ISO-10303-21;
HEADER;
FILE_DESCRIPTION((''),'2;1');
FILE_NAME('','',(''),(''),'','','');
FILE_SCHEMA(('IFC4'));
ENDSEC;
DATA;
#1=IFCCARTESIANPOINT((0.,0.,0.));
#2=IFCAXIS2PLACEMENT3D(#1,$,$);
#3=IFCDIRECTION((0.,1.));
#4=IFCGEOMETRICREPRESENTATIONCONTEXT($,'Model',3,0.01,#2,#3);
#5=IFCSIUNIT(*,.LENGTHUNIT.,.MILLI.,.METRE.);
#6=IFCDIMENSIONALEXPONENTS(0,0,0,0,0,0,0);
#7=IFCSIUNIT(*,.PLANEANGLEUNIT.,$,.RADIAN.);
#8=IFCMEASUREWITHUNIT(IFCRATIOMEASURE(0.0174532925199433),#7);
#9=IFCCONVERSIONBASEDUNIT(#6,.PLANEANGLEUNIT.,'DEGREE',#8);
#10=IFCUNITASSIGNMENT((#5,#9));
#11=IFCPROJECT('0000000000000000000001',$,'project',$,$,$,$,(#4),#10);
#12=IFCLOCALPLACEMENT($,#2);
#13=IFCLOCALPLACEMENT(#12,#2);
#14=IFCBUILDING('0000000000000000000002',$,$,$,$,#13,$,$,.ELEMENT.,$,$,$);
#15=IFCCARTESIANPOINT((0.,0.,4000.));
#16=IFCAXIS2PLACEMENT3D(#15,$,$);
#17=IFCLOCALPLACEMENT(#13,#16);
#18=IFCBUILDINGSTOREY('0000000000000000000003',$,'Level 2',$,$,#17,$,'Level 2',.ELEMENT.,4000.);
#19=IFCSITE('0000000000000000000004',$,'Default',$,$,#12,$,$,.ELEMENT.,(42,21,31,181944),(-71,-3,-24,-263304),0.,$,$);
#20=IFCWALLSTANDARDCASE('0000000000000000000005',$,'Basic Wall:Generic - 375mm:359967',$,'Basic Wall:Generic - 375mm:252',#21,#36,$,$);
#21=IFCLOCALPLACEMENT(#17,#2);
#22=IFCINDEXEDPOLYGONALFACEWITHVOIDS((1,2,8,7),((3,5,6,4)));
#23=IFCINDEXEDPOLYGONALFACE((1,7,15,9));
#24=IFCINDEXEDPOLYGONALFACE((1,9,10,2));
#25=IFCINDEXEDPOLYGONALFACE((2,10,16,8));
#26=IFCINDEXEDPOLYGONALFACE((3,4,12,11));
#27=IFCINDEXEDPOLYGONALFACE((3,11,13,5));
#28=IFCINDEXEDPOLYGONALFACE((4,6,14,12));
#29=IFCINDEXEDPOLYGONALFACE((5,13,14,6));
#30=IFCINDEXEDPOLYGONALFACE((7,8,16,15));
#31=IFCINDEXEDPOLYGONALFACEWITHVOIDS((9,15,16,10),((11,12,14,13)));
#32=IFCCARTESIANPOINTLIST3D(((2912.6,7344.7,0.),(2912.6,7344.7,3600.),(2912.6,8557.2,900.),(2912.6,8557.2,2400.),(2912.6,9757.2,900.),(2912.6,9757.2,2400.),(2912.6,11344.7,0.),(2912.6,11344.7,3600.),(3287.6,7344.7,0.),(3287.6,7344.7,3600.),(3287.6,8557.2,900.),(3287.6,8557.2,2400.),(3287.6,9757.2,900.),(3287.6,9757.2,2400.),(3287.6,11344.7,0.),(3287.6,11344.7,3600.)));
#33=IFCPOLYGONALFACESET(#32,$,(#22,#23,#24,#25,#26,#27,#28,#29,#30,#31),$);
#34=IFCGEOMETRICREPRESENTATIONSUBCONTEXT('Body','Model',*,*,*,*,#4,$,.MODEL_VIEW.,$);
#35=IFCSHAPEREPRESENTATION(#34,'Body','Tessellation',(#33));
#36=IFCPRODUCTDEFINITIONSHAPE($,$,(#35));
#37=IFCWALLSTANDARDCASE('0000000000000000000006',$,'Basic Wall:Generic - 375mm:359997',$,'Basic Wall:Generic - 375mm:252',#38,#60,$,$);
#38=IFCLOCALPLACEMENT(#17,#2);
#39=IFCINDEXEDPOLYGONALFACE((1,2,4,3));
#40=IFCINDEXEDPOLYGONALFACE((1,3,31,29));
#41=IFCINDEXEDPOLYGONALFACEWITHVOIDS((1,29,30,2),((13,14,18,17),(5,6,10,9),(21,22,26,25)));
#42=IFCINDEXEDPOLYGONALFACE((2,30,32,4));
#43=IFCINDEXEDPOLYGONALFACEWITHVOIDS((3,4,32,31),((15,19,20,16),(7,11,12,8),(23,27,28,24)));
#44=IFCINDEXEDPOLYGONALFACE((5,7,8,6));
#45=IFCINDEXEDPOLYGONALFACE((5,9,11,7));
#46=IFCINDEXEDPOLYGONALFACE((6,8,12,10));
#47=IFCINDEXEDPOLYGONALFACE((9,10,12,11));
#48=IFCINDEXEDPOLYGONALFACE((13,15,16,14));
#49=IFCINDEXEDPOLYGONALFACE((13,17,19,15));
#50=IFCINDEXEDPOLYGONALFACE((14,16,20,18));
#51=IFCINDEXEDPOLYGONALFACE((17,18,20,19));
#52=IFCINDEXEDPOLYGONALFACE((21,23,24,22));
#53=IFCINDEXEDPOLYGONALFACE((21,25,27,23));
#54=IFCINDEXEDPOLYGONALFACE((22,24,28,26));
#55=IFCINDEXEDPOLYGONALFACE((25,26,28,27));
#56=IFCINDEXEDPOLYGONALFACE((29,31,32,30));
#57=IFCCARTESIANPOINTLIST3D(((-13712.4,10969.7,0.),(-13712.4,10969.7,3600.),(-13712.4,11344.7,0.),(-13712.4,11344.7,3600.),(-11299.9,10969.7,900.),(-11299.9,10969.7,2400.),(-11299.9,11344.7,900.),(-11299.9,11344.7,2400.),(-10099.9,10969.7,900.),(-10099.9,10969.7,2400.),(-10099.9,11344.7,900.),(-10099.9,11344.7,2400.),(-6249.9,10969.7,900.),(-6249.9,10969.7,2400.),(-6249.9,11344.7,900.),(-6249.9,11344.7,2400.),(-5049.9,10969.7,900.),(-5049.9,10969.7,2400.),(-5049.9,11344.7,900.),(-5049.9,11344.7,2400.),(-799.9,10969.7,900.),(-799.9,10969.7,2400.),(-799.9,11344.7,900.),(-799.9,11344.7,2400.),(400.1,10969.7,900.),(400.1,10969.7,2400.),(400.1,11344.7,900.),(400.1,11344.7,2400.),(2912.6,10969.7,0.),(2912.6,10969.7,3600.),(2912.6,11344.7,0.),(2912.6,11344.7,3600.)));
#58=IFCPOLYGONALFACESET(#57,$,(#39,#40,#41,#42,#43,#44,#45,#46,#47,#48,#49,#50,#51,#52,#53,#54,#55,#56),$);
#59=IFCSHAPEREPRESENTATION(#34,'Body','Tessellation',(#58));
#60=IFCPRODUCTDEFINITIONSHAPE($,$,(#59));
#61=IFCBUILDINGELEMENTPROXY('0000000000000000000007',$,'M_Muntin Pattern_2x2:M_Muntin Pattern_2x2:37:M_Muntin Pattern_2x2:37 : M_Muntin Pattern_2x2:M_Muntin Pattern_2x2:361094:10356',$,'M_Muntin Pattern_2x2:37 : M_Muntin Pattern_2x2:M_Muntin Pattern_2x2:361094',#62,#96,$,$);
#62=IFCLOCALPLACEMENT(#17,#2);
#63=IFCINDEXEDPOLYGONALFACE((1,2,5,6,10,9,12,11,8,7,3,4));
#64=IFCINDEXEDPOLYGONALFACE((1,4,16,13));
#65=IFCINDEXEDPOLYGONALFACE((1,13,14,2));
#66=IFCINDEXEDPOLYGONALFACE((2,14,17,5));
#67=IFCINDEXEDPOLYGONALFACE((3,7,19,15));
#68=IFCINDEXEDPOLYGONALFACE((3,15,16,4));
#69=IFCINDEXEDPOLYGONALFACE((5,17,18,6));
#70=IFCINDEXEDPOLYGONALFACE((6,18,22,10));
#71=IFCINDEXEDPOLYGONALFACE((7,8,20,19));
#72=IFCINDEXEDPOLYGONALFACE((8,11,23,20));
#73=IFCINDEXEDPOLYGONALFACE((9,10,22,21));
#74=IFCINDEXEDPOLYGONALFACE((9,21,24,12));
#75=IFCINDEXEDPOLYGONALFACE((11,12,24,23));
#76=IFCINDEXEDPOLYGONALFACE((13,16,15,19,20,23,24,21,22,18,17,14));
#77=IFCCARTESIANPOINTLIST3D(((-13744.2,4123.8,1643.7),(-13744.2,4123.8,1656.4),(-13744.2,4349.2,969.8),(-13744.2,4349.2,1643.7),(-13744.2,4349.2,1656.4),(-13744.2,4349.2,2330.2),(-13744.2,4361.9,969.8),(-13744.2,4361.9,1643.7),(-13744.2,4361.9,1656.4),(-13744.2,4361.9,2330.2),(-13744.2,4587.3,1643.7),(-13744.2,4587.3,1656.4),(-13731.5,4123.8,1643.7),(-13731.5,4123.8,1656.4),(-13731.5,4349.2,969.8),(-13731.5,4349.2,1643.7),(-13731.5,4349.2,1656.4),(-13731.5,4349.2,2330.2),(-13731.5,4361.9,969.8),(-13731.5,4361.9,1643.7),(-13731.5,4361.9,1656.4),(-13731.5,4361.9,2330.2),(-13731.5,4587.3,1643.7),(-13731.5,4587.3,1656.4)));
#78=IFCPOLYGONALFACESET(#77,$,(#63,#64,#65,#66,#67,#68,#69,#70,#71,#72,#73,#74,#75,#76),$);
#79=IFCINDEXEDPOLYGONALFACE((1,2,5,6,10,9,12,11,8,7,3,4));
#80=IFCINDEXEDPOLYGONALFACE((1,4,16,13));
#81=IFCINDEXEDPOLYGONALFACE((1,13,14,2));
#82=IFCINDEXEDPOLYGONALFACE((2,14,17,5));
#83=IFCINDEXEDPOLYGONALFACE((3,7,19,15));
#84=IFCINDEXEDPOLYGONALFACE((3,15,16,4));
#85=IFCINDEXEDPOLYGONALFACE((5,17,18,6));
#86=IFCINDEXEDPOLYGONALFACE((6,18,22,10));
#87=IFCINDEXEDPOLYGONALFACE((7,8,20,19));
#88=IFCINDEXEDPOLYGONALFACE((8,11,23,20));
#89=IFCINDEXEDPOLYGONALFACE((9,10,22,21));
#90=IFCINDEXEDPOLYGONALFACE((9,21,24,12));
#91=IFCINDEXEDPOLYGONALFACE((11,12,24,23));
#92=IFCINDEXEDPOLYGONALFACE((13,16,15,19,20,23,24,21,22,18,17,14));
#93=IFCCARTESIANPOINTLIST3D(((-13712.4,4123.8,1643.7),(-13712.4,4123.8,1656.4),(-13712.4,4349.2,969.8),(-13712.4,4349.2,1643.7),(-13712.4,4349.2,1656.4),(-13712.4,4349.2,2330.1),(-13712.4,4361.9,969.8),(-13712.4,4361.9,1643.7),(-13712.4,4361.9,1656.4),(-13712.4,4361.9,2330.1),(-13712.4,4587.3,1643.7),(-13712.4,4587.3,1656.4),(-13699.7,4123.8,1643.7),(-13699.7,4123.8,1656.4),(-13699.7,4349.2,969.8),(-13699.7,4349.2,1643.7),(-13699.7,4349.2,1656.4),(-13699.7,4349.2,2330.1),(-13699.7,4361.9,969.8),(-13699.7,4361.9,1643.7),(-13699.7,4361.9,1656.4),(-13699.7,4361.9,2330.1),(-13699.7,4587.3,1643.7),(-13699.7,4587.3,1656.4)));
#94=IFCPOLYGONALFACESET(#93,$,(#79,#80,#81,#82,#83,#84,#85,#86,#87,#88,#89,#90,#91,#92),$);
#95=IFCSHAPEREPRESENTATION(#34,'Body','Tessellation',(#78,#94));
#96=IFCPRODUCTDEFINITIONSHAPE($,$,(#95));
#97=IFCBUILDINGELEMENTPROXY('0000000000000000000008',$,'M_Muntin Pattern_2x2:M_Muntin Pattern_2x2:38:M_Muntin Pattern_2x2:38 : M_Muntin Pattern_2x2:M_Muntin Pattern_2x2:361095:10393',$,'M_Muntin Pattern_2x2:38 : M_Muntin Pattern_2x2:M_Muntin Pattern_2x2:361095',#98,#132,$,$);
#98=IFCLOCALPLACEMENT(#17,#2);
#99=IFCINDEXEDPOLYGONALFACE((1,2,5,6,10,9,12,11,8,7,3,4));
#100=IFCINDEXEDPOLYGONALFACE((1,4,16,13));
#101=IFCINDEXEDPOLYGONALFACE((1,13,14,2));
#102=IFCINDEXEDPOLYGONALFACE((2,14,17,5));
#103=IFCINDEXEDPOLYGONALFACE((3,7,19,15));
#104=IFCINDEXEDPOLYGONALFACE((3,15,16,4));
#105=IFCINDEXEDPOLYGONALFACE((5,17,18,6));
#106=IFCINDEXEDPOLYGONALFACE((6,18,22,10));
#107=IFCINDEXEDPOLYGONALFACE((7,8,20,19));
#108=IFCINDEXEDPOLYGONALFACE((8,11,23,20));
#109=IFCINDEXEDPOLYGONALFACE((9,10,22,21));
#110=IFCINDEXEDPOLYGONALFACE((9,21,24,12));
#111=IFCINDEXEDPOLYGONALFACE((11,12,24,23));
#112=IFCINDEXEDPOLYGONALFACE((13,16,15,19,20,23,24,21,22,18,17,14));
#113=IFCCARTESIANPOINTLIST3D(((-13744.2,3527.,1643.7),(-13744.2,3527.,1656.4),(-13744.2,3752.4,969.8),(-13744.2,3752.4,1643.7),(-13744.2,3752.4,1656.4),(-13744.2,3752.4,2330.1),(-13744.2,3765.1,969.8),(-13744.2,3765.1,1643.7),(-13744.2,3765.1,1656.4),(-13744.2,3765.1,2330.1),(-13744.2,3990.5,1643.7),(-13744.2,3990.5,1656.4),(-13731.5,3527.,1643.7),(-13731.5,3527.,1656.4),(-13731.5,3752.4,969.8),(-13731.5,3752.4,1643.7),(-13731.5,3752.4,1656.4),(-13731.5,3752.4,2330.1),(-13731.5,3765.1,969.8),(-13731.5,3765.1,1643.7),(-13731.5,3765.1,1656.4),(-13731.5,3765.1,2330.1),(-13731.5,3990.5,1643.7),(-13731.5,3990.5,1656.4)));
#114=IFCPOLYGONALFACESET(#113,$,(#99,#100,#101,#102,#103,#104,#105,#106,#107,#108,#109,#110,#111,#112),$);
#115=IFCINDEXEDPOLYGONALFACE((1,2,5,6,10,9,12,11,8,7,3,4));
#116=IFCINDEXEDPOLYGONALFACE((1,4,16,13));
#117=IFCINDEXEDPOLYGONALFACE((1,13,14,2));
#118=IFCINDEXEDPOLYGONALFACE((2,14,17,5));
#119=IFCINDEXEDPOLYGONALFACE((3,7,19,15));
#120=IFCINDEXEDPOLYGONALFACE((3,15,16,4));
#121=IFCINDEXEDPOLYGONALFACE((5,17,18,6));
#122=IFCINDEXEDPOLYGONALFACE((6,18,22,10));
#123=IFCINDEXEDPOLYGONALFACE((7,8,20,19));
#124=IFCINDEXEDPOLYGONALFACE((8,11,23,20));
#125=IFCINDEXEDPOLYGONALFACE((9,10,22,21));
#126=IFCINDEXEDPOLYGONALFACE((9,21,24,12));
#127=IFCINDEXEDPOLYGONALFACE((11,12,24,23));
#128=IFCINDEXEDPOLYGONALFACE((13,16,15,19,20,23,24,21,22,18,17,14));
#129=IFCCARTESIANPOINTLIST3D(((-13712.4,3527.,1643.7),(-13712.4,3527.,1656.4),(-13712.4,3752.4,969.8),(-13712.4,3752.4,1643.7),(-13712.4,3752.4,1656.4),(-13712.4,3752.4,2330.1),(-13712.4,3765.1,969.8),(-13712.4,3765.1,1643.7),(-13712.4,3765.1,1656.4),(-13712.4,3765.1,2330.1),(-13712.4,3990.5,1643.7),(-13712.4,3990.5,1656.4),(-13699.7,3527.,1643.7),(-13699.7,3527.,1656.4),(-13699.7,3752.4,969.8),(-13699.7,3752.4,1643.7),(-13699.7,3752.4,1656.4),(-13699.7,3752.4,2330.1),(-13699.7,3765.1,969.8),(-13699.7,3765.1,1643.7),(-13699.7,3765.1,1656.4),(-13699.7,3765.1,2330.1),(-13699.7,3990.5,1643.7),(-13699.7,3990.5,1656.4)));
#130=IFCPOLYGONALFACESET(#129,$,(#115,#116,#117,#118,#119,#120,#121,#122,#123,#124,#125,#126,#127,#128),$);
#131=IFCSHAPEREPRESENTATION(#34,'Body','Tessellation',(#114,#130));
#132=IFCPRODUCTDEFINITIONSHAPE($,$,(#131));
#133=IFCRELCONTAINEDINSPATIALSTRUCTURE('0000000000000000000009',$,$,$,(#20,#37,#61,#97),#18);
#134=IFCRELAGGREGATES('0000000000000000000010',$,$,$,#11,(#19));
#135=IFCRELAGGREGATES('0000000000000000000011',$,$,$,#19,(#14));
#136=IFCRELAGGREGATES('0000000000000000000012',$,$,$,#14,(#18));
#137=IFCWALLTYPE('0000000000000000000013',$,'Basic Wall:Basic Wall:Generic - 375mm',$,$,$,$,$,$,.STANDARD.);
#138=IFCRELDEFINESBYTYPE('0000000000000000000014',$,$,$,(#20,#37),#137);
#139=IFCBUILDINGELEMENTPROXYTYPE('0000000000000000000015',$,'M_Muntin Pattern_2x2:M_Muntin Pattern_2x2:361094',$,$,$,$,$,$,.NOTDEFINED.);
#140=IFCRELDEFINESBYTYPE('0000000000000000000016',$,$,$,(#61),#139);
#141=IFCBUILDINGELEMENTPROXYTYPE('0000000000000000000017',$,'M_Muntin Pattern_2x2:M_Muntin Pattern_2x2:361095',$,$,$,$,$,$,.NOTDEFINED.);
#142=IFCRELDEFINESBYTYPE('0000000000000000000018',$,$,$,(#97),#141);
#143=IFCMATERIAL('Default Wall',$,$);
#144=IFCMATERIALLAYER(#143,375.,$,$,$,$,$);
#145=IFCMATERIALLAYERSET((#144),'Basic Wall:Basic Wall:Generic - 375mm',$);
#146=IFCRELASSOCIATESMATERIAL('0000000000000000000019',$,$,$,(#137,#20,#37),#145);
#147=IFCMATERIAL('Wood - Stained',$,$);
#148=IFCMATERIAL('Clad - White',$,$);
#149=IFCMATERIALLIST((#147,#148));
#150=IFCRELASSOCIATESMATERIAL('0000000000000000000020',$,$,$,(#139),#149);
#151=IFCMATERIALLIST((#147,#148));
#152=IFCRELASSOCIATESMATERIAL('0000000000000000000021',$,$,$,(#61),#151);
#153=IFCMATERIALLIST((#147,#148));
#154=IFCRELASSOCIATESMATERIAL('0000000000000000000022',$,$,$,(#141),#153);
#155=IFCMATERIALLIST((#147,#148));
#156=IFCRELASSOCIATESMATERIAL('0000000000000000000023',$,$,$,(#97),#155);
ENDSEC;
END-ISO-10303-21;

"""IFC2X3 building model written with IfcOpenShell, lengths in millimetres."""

from ifc_helpers import new_model, entity, si_unit, converted_unit, direction, frame, frame_2d, origin, place, context, subcontext, project, spatial, polyline, rectangle, outline, extrude, source, transform, mapped, material, material_list, layer, layer_set, layer_usage, type_object, type_shapes, element, save


model = new_model("IFC2X3")

# Units and contexts
model_context = context("Model", 3, precision=0.01, world=origin(), true_north=direction((0.0, 1.0)))
body_context = subcontext(model_context, "Body", "Model", "MODEL_VIEW")
ifc_project = project(units=[si_unit("LENGTHUNIT", "METRE", prefix="MILLI"), converted_unit("PLANEANGLEUNIT", "DEGREE", entity("IfcRatioMeasure", 0.0174532925199433), si_unit("PLANEANGLEUNIT", "RADIAN"), dimensions=[0, 0, 0, 0, 0, 0, 0])], contexts=[model_context])

# Site, building, storey
site_placement = place(None, origin())
site = spatial("IfcSite", under=ifc_project, at=site_placement, Name="Default", CompositionType="ELEMENT", RefLatitude=(42, 21, 31, 181944), RefLongitude=(-71, -3, -24, -263304), RefElevation=0.0)
building_placement = place(site_placement, origin())
building = spatial("IfcBuilding", under=site, at=building_placement, CompositionType="ELEMENT")
storey_placement = place(building_placement, frame((0.0, 0.0, 4000.0)))
storey = spatial("IfcBuildingStorey", under=building, at=storey_placement, Name="Level 2", LongName="Level 2", CompositionType="ELEMENT", Elevation=4000.0)

# Wall, opening
ifc_material_1 = material(Name="Default Wall")
ifc_layer = layer(ifc_material_1, 375.0)
ifc_layer_set = layer_set([ifc_layer], Name="Basic Wall:Basic Wall:Generic - 375mm")
ifc_layer_usage_1 = layer_usage(ifc_layer_set, "AXIS2", "NEGATIVE", 187.5)
wall_type = type_object("IfcWallType", Name="Basic Wall:Basic Wall:Generic - 375mm", PredefinedType="STANDARD", material=ifc_layer_set)
wall_1_placement = place(storey_placement, frame((3100.1, 7344.7, 0.0), z_axis=(0.0, 0.0, 1.0), x_axis=(0.0, 1.0, 0.0)))
wall_1 = element("IfcWallStandardCase", 1, at=wall_1_placement, inside=storey, type_object=wall_type, material=ifc_layer_usage_1, Name="Basic Wall:Generic - 375mm:359967", ObjectType="Basic Wall:Generic - 375mm:252", context=body_context, shape_type="SweptSolid", body=[
    extrude(rectangle(XDim=4000.0, YDim=375.0, at=frame_2d((2000.0, 0.0), x_axis=(-1.0, 0.0))), origin(), (0.0, 0.0, 1.0), 3600.0),
])
opening_1_placement = place(wall_1_placement, frame((-7344.7, 3100.1, 0.0), z_axis=(0.0, 0.0, 1.0), x_axis=(0.0, -1.0, 0.0)))
element("IfcOpeningElement", 2, at=opening_1_placement, cuts=wall_1, ObjectType="Opening", context=body_context, shape_type="SweptSolid", body=[
    extrude(rectangle(XDim=1500.0, YDim=1200.0, at=frame_2d((0.0, 0.0), x_axis=(0.0, 1.0))), frame((3291.3, 9157.2, 1650.0), z_axis=(-1.0, 0.0, 0.0), x_axis=(0.0, -1.0, 0.0)), (0.0, 0.0, 1.0), 382.5),
])

# Wall, openings
ifc_layer_usage_2 = layer_usage(ifc_layer_set, "AXIS2", "NEGATIVE", 187.5)
wall_2_placement = place(storey_placement, frame((2912.6, 11157.2, 0.0), z_axis=(0.0, 0.0, 1.0), x_axis=(-1.0, 0.0, 0.0)))
wall_2 = element("IfcWallStandardCase", 3, at=wall_2_placement, inside=storey, type_object=wall_type, material=ifc_layer_usage_2, Name="Basic Wall:Generic - 375mm:359997", ObjectType="Basic Wall:Generic - 375mm:252", context=body_context, shape_type="SweptSolid", body=[
    extrude(rectangle(XDim=16625.0, YDim=375.0, at=frame_2d((8312.5, 0.0), x_axis=(-1.0, 0.0))), origin(), (0.0, 0.0, 1.0), 3600.0),
])
opening_2_placement = place(wall_2_placement, frame((2912.6, 11157.2, 0.0), z_axis=(0.0, 0.0, 1.0), x_axis=(-1.0, 0.0, 0.0)))
element("IfcOpeningElement", 4, at=opening_2_placement, cuts=wall_2, ObjectType="Opening", context=body_context, shape_type="SweptSolid", body=[
    extrude(rectangle(XDim=1500.0, YDim=1200.0, at=frame_2d((0.0, 0.0), x_axis=(0.0, 1.0))), frame((-5649.9, 11348.4, 1650.0), z_axis=(0.0, -1.0, 0.0), x_axis=(1.0, 0.0, 0.0)), (0.0, 0.0, 1.0), 382.5),
])
opening_3_placement = place(wall_2_placement, frame((2912.6, 11157.2, 0.0), z_axis=(0.0, 0.0, 1.0), x_axis=(-1.0, 0.0, 0.0)))
element("IfcOpeningElement", 5, at=opening_3_placement, cuts=wall_2, ObjectType="Opening", context=body_context, shape_type="SweptSolid", body=[
    extrude(rectangle(XDim=1500.0, YDim=1200.0, at=frame_2d((0.0, 0.0), x_axis=(0.0, 1.0))), frame((-199.9, 11348.4, 1650.0), z_axis=(0.0, -1.0, 0.0), x_axis=(1.0, 0.0, 0.0)), (0.0, 0.0, 1.0), 382.5),
])
opening_4_placement = place(wall_2_placement, frame((2912.6, 11157.2, 0.0), z_axis=(0.0, 0.0, 1.0), x_axis=(-1.0, 0.0, 0.0)))
element("IfcOpeningElement", 6, at=opening_4_placement, cuts=wall_2, ObjectType="Opening", context=body_context, shape_type="SweptSolid", body=[
    extrude(rectangle(XDim=1500.0, YDim=1200.0, at=frame_2d((0.0, 0.0), x_axis=(0.0, 1.0))), frame((-10699.9, 11348.4, 1650.0), z_axis=(0.0, -1.0, 0.0), x_axis=(1.0, 0.0, 0.0)), (0.0, 0.0, 1.0), 382.5),
])

# Building element proxies
ifc_material_2 = material(Name="Wood - Stained")
ifc_material_3 = material(Name="Clad - White")
ifc_material_list_1 = material_list([ifc_material_2, ifc_material_3])
ifc_material_list_2 = material_list([ifc_material_2, ifc_material_3])
building_element_proxy_type_1 = type_object("IfcBuildingElementProxyType", Name="M_Muntin Pattern_2x2:M_Muntin Pattern_2x2:361094", PredefinedType="NOTDEFINED", material=ifc_material_list_2)
shared_shape_1 = source(origin(), body_context, "Body", "SweptSolid", [
    extrude(outline(polyline([(-6.4, -680.2), (6.3, -680.2), (6.3, -6.4), (231.7, -6.4), (231.7, 6.3), (6.3, 6.3), (6.3, 680.2), (-6.4, 680.2), (-6.4, 6.3), (-231.7, 6.3), (-231.7, -6.4), (-6.4, -6.4), (-6.4, -680.2)])), frame((-13744.2, 4355.6, 5650.0), z_axis=(1.0, 0.0, 0.0), x_axis=(0.0, -1.0, 0.0)), (0.0, 0.0, 1.0), 12.7),
    extrude(outline(polyline([(-6.4, -680.1), (6.3, -680.1), (6.3, -6.4), (231.7, -6.4), (231.7, 6.3), (6.3, 6.3), (6.3, 680.2), (-6.4, 680.2), (-6.4, 6.3), (-231.7, 6.3), (-231.7, -6.4), (-6.4, -6.4), (-6.4, -680.1)])), frame((-13712.4, 4355.6, 5650.0), z_axis=(1.0, 0.0, 0.0), x_axis=(0.0, -1.0, 0.0)), (0.0, 0.0, 1.0), 12.7),
])
type_shapes(building_element_proxy_type_1, [shared_shape_1])
proxy_1_placement = place(storey_placement, frame((0.0, 0.0, -4000.0)))
element("IfcBuildingElementProxy", 7, at=proxy_1_placement, inside=storey, type_object=building_element_proxy_type_1, material=ifc_material_list_1, Name="M_Muntin Pattern_2x2:M_Muntin Pattern_2x2:37:M_Muntin Pattern_2x2:37 : M_Muntin Pattern_2x2:M_Muntin Pattern_2x2:361094:10356", ObjectType="M_Muntin Pattern_2x2:37 : M_Muntin Pattern_2x2:M_Muntin Pattern_2x2:361094", context=body_context, shape_type="MappedRepresentation", body=[
    mapped(shared_shape_1, transform((0.0, 0.0, 0.0), scale=1.0)),
])
ifc_material_list_3 = material_list([ifc_material_2, ifc_material_3])
ifc_material_list_4 = material_list([ifc_material_2, ifc_material_3])
building_element_proxy_type_2 = type_object("IfcBuildingElementProxyType", Name="M_Muntin Pattern_2x2:M_Muntin Pattern_2x2:361095", PredefinedType="NOTDEFINED", material=ifc_material_list_4)
shared_shape_2 = source(origin(), body_context, "Body", "SweptSolid", [
    extrude(outline(polyline([(-680.1, 6.4), (-680.1, -6.3), (-6.4, -6.3), (-6.4, -231.7), (6.3, -231.7), (6.3, -6.3), (680.2, -6.3), (680.2, 6.4), (6.3, 6.4), (6.3, 231.7), (-6.4, 231.7), (-6.4, 6.4), (-680.1, 6.4)])), frame((-13744.2, 3758.7, 5650.0), z_axis=(-1.0, 0.0, 0.0), x_axis=(0.0, 0.0, -1.0)), (0.0, 0.0, -1.0), 12.7),
    extrude(outline(polyline([(-680.1, 6.4), (-680.1, -6.3), (-6.4, -6.3), (-6.4, -231.7), (6.3, -231.7), (6.3, -6.3), (680.2, -6.3), (680.2, 6.4), (6.3, 6.4), (6.3, 231.7), (-6.4, 231.7), (-6.4, 6.4), (-680.1, 6.4)])), frame((-13712.4, 3758.7, 5650.0), z_axis=(-1.0, 0.0, 0.0), x_axis=(0.0, 0.0, -1.0)), (0.0, 0.0, -1.0), 12.7),
])
type_shapes(building_element_proxy_type_2, [shared_shape_2])
proxy_2_placement = place(storey_placement, frame((0.0, 0.0, -4000.0)))
element("IfcBuildingElementProxy", 8, at=proxy_2_placement, inside=storey, type_object=building_element_proxy_type_2, material=ifc_material_list_3, Name="M_Muntin Pattern_2x2:M_Muntin Pattern_2x2:38:M_Muntin Pattern_2x2:38 : M_Muntin Pattern_2x2:M_Muntin Pattern_2x2:361095:10393", ObjectType="M_Muntin Pattern_2x2:38 : M_Muntin Pattern_2x2:M_Muntin Pattern_2x2:361095", context=body_context, shape_type="MappedRepresentation", body=[
    mapped(shared_shape_2, transform((0.0, 0.0, 0.0), scale=1.0)),
])

save(model, "model.ifc")
